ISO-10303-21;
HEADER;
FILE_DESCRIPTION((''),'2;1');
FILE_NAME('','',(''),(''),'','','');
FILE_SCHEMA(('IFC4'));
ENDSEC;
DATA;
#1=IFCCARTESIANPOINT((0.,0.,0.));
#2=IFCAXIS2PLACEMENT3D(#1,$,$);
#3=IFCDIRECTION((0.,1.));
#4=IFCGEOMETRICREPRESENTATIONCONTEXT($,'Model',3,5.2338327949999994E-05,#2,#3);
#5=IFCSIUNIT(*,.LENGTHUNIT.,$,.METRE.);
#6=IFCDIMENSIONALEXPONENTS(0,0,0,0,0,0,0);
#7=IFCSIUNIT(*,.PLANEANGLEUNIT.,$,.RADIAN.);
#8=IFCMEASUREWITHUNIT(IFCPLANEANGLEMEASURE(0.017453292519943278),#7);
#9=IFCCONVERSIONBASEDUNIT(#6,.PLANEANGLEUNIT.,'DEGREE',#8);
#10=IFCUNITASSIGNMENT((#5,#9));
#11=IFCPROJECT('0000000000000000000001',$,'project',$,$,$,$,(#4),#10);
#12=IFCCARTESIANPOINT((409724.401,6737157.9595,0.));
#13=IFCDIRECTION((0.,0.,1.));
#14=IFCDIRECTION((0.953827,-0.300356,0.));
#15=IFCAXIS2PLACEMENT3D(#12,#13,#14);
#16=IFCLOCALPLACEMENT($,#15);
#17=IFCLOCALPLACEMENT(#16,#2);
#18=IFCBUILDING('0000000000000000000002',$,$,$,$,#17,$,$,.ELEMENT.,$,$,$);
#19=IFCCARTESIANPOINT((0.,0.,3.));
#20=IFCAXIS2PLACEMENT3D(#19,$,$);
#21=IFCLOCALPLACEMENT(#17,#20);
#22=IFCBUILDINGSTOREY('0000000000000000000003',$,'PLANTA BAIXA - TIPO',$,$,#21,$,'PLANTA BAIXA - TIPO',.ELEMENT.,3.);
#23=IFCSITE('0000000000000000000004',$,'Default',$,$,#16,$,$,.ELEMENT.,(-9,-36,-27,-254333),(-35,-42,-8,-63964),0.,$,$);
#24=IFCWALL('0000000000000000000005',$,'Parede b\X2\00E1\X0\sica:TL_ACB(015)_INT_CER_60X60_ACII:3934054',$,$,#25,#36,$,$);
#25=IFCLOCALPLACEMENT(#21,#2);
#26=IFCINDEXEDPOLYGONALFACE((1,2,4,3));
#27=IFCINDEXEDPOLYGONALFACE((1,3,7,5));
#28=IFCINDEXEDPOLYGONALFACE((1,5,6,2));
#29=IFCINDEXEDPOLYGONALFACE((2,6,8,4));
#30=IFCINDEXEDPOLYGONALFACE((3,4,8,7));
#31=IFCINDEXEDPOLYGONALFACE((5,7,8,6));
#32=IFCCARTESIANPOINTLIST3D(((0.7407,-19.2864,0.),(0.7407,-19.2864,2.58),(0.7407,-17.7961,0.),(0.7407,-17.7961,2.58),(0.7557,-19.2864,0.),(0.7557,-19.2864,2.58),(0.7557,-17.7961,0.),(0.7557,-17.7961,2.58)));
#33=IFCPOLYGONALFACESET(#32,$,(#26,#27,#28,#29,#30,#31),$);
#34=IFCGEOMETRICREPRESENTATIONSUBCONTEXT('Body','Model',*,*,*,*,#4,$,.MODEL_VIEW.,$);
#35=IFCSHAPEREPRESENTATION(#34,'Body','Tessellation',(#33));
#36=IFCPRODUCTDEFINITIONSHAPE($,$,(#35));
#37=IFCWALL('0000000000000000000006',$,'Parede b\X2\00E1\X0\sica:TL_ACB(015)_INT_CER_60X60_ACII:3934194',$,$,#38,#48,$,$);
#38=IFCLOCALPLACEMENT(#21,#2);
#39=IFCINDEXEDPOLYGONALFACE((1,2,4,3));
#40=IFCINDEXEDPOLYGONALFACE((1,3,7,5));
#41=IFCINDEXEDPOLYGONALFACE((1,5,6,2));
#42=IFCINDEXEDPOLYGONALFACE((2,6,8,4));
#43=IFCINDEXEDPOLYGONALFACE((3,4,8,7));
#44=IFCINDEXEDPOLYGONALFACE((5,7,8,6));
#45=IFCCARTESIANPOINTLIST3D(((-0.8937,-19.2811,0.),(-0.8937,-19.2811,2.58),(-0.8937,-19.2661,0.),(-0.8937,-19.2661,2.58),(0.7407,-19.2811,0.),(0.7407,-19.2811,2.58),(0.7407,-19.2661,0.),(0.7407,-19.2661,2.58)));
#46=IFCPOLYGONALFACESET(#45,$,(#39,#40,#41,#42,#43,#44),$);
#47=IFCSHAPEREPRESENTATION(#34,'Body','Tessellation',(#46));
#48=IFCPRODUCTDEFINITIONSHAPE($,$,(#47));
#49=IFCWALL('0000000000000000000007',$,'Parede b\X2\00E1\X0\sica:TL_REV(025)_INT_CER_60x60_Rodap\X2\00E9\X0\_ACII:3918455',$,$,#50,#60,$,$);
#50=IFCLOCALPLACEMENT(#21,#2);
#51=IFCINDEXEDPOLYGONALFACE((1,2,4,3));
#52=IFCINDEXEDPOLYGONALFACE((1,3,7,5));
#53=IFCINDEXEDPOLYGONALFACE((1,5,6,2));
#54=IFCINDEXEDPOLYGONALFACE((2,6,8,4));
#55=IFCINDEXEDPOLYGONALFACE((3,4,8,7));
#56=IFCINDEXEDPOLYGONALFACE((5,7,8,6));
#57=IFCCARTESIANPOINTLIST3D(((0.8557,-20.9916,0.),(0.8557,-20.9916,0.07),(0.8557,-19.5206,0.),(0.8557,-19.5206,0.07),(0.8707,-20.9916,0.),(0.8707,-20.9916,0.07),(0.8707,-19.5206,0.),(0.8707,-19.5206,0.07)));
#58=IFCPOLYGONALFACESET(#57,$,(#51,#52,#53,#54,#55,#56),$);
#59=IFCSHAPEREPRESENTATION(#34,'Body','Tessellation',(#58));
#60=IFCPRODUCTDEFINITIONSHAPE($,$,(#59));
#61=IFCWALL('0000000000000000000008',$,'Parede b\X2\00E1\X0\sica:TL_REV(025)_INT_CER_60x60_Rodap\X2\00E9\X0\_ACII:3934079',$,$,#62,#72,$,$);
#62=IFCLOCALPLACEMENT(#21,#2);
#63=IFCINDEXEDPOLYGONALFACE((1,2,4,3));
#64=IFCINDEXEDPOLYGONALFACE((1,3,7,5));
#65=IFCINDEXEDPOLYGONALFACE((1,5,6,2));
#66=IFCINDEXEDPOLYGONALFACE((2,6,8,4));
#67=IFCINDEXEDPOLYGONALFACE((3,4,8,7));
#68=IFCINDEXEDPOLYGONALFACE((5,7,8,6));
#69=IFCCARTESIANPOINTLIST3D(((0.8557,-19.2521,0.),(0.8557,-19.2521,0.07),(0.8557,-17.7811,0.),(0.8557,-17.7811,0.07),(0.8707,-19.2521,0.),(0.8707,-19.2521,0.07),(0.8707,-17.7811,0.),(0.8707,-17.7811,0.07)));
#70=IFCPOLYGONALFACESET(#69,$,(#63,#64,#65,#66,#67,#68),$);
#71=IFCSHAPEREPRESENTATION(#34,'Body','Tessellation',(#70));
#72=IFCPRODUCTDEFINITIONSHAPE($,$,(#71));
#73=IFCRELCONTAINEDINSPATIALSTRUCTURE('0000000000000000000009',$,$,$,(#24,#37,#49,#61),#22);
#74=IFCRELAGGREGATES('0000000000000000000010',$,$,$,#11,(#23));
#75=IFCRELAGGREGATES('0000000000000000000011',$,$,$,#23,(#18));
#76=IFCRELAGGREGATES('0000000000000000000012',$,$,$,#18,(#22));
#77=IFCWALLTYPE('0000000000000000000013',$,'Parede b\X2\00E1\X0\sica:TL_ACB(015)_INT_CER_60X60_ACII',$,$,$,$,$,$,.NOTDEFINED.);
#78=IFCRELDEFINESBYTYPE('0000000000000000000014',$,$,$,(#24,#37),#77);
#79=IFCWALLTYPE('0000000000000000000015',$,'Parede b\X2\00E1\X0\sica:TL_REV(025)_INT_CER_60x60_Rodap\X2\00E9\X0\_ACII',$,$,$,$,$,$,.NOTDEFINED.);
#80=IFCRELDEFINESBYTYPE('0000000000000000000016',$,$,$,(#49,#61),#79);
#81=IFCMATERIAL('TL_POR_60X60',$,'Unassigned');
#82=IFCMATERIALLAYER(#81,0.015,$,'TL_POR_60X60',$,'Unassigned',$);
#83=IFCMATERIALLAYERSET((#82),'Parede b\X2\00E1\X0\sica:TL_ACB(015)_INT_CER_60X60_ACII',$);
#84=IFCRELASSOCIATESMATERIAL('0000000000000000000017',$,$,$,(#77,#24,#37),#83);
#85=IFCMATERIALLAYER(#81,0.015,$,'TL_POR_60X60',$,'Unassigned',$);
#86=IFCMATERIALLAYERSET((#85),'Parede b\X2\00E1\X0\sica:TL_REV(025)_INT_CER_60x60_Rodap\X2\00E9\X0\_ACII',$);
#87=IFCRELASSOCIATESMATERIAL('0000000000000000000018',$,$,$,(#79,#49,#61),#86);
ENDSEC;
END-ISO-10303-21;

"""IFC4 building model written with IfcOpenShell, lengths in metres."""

from ifc_helpers import new_model, entity, si_unit, converted_unit, direction, frame, frame_2d, origin, place, context, subcontext, project, spatial, rectangle, extrude, material, layer, layer_set, layer_usage, type_object, element, save


model = new_model("IFC4")

# Units and contexts
model_context = context("Model", 3, precision=5.2338327949999994e-05, world=origin(), true_north=direction((0.0, 1.0)))
body_context = subcontext(model_context, "Body", "Model", "MODEL_VIEW")
ifc_project = project(units=[si_unit("LENGTHUNIT", "METRE"), converted_unit("PLANEANGLEUNIT", "DEGREE", entity("IfcPlaneAngleMeasure", 0.017453292519943278), si_unit("PLANEANGLEUNIT", "RADIAN"), dimensions=[0, 0, 0, 0, 0, 0, 0])], contexts=[model_context])

# Site, building, storey
site_placement = place(None, frame((409724.401, 6737157.9595, 0.0), z_axis=(0.0, 0.0, 1.0), x_axis=(0.953827, -0.300356, 0.0)))
site = spatial("IfcSite", under=ifc_project, at=site_placement, Name="Default", CompositionType="ELEMENT", RefLatitude=(-9, -36, -27, -254333), RefLongitude=(-35, -42, -8, -63964), RefElevation=0.0)
building_placement = place(site_placement, origin())
building = spatial("IfcBuilding", under=site, at=building_placement, CompositionType="ELEMENT")
storey_placement = place(building_placement, frame((0.0, 0.0, 3.0)))
storey = spatial("IfcBuildingStorey", under=building, at=storey_placement, Name="PLANTA BAIXA - TIPO", LongName="PLANTA BAIXA - TIPO", CompositionType="ELEMENT", Elevation=3.0)

# Walls
ifc_material_1 = material(Name="TL_POR_60X60", Category="Unassigned")
ifc_layer_1 = layer(ifc_material_1, 0.015, Name="TL_POR_60X60", Category="Unassigned")
ifc_layer_set_1 = layer_set([ifc_layer_1], Name="Parede básica:TL_ACB(015)_INT_CER_60X60_ACII")
wall_type_1 = type_object("IfcWallType", Name="Parede básica:TL_ACB(015)_INT_CER_60X60_ACII", PredefinedType="NOTDEFINED", material=ifc_layer_set_1)
ifc_layer_usage_1 = layer_usage(ifc_layer_set_1, "AXIS2", "NEGATIVE", 0.0075)
wall_1_placement = place(storey_placement, frame((0.7482, -19.2864, 0.0), z_axis=(0.0, 0.0, 1.0), x_axis=(0.0, 1.0, 0.0)))
element("IfcWall", 1, at=wall_1_placement, inside=storey, type_object=wall_type_1, material=ifc_layer_usage_1, Name="Parede básica:TL_ACB(015)_INT_CER_60X60_ACII:3934054", context=body_context, shape_type="SweptSolid", body=[
    extrude(rectangle(XDim=1.4902, YDim=0.015, at=frame_2d((0.7451, 0.0), x_axis=(-1.0, 0.0))), origin(), (0.0, 0.0, 1.0), 2.58),
])
ifc_layer_usage_2 = layer_usage(ifc_layer_set_1, "AXIS2", "POSITIVE", -0.0075)
wall_2_placement = place(storey_placement, frame((0.7407, -19.2736, 0.0), z_axis=(0.0, 0.0, 1.0), x_axis=(-1.0, 0.0, 0.0)))
element("IfcWall", 2, at=wall_2_placement, inside=storey, type_object=wall_type_1, material=ifc_layer_usage_2, Name="Parede básica:TL_ACB(015)_INT_CER_60X60_ACII:3934194", context=body_context, shape_type="SweptSolid", body=[
    extrude(rectangle(XDim=1.6345, YDim=0.015, at=frame_2d((0.8172, 0.0), x_axis=(-1.0, 0.0))), origin(), (0.0, 0.0, 1.0), 2.58),
])
ifc_layer_2 = layer(ifc_material_1, 0.015, Name="TL_POR_60X60", Category="Unassigned")
ifc_layer_set_2 = layer_set([ifc_layer_2], Name="Parede básica:TL_REV(025)_INT_CER_60x60_Rodapé_ACII")
ifc_layer_usage_3 = layer_usage(ifc_layer_set_2, "AXIS2", "NEGATIVE", 0.0075)
wall_type_2 = type_object("IfcWallType", Name="Parede básica:TL_REV(025)_INT_CER_60x60_Rodapé_ACII", PredefinedType="NOTDEFINED", material=ifc_layer_set_2)
wall_3_placement = place(storey_placement, frame((0.8632, -19.5206, 0.0), z_axis=(0.0, 0.0, 1.0), x_axis=(0.0, -1.0, 0.0)))
element("IfcWall", 3, at=wall_3_placement, inside=storey, type_object=wall_type_2, material=ifc_layer_usage_3, Name="Parede básica:TL_REV(025)_INT_CER_60x60_Rodapé_ACII:3918455", context=body_context, shape_type="SweptSolid", body=[
    extrude(rectangle(XDim=1.471, YDim=0.015, at=frame_2d((0.7355, 0.0), x_axis=(-1.0, 0.0))), origin(), (0.0, 0.0, 1.0), 0.07),
])
ifc_layer_usage_4 = layer_usage(ifc_layer_set_2, "AXIS2", "POSITIVE", -0.0075)
wall_4_placement = place(storey_placement, frame((0.8632, -19.2521, 0.0), z_axis=(0.0, 0.0, 1.0), x_axis=(0.0, 1.0, 0.0)))
element("IfcWall", 4, at=wall_4_placement, inside=storey, type_object=wall_type_2, material=ifc_layer_usage_4, Name="Parede básica:TL_REV(025)_INT_CER_60x60_Rodapé_ACII:3934079", context=body_context, shape_type="SweptSolid", body=[
    extrude(rectangle(XDim=1.471, YDim=0.015, at=frame_2d((0.7355, 0.0), x_axis=(-1.0, 0.0))), origin(), (0.0, 0.0, 1.0), 0.07),
])

save(model, "model.ifc")
